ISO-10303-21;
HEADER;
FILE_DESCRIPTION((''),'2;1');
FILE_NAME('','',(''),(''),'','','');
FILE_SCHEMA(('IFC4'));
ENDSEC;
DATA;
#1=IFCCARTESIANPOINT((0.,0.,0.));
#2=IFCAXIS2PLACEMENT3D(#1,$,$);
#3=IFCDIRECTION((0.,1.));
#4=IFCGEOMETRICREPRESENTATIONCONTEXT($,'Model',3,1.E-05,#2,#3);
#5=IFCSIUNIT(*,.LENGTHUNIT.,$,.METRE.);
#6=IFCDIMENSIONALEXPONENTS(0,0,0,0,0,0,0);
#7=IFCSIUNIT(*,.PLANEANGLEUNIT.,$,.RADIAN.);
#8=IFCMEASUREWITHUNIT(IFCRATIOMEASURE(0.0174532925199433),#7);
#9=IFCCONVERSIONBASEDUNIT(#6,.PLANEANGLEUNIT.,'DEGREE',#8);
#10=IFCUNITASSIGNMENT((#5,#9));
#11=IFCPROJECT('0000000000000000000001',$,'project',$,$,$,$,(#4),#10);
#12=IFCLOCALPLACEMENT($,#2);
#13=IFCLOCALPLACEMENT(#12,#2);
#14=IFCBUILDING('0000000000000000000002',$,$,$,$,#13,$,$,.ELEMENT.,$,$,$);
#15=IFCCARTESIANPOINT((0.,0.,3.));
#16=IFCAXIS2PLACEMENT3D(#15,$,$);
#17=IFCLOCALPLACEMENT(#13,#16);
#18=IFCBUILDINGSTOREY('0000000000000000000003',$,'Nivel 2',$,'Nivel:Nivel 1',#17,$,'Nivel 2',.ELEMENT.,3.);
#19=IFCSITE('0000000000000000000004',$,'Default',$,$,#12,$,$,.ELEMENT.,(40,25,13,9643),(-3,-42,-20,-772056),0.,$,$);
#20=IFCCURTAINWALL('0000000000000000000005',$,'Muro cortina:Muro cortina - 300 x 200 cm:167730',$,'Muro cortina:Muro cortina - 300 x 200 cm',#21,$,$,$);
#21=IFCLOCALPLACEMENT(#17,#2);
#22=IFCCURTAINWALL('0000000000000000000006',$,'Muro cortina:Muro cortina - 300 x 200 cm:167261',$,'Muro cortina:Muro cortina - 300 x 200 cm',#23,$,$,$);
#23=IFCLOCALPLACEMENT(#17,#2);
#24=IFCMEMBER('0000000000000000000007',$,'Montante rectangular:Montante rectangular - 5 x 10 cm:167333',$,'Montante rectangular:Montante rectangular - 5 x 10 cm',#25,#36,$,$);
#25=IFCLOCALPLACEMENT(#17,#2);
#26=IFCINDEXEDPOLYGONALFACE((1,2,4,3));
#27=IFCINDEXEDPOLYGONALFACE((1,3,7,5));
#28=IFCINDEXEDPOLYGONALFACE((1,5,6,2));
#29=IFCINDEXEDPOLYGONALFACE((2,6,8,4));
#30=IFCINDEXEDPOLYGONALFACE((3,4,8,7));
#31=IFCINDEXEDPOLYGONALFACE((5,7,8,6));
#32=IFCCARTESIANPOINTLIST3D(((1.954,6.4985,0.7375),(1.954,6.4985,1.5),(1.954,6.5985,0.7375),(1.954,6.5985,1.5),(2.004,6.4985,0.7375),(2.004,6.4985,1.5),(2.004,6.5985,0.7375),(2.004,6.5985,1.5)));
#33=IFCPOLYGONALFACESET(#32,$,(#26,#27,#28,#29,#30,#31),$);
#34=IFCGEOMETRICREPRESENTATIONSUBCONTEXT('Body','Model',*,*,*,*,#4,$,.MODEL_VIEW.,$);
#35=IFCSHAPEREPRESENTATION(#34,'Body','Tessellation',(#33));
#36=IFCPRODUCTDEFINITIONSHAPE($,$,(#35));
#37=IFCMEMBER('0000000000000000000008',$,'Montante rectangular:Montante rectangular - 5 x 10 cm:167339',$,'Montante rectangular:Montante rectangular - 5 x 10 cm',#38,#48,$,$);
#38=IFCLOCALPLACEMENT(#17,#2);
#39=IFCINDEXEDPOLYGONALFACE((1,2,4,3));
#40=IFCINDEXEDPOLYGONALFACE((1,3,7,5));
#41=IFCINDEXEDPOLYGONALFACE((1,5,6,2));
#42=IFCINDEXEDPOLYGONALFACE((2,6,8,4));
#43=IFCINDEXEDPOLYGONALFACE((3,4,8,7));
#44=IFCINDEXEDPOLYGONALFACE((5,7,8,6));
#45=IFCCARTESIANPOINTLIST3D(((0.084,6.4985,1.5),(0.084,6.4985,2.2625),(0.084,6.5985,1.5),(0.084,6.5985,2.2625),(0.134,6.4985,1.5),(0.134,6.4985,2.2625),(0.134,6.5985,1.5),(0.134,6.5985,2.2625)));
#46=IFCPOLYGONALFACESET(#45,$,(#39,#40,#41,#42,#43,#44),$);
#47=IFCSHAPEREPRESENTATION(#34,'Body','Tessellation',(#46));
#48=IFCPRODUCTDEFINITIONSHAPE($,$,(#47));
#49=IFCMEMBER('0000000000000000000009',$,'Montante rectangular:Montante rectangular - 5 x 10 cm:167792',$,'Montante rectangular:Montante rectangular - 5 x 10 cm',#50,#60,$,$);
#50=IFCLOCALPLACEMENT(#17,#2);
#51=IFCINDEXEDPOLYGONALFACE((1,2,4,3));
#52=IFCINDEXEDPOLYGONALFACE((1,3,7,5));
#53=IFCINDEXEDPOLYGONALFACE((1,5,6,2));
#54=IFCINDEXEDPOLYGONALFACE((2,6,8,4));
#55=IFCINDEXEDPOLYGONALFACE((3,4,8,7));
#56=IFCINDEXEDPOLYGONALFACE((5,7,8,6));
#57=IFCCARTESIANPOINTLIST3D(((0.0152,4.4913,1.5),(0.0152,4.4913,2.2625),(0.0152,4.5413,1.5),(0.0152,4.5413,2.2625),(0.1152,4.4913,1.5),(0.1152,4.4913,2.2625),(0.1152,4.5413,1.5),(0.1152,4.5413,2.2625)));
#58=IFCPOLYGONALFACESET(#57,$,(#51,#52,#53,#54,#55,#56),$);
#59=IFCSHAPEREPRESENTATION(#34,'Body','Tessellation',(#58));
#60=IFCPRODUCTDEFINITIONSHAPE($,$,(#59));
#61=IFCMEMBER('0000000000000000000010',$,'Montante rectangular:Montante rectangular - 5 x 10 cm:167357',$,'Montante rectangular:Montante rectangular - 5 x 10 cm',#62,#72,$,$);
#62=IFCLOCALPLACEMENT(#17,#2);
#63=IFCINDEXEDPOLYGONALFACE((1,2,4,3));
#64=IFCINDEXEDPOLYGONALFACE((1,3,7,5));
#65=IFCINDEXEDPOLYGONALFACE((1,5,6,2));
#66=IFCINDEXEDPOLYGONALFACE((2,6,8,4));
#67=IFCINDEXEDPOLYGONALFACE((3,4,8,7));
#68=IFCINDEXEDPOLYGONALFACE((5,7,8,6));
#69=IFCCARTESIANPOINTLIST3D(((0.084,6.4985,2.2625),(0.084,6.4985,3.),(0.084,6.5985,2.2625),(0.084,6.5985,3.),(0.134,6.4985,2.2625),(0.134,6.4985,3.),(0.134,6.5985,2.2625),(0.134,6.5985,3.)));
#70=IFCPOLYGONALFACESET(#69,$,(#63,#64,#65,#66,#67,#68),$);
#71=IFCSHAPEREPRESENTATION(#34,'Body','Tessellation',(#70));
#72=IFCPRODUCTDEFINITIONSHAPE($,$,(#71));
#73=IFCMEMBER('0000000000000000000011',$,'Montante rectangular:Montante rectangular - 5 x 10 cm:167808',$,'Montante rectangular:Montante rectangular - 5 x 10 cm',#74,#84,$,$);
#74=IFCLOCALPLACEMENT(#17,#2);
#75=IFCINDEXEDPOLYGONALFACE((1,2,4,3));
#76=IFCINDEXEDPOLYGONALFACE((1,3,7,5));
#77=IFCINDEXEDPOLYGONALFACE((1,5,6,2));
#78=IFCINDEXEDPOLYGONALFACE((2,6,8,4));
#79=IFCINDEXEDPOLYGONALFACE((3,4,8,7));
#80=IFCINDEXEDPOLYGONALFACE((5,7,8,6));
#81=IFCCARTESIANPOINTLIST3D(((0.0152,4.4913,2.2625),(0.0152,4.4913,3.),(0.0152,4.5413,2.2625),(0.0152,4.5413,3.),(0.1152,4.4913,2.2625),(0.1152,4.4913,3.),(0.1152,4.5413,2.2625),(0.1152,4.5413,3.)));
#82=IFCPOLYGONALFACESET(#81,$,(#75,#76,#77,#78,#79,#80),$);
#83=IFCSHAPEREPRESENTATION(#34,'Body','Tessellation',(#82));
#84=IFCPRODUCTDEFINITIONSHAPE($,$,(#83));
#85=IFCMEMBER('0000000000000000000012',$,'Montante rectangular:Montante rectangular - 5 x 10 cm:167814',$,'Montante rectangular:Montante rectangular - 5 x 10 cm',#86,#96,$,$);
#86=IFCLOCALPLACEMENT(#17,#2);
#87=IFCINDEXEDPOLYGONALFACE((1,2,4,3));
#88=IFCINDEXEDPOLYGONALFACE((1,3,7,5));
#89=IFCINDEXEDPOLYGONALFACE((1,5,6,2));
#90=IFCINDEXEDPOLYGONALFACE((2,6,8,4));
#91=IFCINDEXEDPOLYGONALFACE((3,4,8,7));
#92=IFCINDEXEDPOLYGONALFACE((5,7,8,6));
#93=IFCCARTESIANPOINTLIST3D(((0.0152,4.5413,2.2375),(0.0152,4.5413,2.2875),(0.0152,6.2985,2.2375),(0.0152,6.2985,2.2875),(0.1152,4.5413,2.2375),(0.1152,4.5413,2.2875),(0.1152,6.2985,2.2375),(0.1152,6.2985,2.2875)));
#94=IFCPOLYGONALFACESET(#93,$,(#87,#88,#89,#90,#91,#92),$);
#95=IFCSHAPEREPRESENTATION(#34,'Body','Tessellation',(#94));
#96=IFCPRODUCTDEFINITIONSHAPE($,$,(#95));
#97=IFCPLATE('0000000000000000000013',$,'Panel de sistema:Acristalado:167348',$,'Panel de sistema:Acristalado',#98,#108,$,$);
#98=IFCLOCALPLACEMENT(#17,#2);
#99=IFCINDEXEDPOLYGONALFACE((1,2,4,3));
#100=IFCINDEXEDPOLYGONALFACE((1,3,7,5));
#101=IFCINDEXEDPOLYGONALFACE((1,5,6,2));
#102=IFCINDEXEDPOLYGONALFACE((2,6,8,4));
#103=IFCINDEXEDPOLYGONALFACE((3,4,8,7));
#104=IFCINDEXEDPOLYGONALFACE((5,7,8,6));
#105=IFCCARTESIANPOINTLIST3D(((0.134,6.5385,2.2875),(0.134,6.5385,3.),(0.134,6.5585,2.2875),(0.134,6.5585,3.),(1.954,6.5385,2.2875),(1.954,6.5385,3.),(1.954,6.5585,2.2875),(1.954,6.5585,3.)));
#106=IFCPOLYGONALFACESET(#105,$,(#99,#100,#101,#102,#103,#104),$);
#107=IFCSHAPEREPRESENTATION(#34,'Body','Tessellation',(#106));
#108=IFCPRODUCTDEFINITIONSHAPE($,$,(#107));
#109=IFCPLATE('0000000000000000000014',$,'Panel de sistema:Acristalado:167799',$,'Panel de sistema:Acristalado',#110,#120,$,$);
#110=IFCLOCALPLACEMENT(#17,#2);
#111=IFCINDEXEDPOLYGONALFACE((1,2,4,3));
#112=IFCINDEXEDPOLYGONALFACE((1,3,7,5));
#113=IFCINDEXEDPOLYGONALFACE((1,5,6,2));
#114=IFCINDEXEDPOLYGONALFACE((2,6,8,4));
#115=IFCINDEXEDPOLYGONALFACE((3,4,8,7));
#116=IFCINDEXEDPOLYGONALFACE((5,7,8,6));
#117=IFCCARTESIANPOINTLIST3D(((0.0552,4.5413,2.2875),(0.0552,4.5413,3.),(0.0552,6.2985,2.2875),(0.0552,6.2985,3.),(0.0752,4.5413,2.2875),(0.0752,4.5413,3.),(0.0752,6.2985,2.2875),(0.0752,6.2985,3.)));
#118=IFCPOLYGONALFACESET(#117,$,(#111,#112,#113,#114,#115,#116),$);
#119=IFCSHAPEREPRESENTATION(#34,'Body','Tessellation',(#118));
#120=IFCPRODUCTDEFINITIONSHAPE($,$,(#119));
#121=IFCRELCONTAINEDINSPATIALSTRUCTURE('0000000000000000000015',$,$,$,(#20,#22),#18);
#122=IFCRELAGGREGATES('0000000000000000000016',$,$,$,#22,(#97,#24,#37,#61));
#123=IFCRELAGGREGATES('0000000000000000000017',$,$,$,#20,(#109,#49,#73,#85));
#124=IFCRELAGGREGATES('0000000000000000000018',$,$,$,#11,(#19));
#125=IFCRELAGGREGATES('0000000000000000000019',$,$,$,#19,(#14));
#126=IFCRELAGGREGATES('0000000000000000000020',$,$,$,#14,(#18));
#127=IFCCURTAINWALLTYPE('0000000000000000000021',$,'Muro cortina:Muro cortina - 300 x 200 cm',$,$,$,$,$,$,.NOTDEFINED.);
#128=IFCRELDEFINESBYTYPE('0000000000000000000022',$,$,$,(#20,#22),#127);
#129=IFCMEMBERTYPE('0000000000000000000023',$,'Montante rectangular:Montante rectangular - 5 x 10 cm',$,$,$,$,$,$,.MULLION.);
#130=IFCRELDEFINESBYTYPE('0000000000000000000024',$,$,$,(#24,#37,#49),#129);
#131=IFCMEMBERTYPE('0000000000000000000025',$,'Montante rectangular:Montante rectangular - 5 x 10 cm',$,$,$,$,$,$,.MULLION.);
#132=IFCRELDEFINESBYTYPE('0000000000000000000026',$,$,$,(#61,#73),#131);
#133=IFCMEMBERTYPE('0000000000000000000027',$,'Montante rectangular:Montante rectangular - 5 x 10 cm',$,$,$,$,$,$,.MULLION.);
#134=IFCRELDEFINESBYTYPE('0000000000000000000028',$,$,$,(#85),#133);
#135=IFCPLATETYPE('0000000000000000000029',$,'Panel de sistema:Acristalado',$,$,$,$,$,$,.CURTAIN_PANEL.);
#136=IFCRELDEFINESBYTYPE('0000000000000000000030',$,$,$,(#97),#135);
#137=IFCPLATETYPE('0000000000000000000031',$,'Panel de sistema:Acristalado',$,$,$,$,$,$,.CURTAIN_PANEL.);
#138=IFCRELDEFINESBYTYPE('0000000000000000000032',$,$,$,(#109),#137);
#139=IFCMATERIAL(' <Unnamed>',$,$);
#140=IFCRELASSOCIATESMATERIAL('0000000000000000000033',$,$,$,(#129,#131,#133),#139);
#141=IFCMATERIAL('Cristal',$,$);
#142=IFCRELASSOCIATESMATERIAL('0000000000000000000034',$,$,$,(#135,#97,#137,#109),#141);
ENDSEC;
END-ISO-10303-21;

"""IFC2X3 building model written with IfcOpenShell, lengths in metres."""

from ifc_helpers import new_model, entity, si_unit, converted_unit, direction, frame, origin, origin_2d_with_axis, place, context, subcontext, project, spatial, rectangle, extrude, source, transform, mapped, material, type_object, type_shapes, element, aggregate, save


model = new_model("IFC2X3")

# Units and contexts
model_context = context("Model", 3, precision=1e-05, world=origin(), true_north=direction((0.0, 1.0)))
body_context = subcontext(model_context, "Body", "Model", "MODEL_VIEW")
ifc_project = project(units=[si_unit("LENGTHUNIT", "METRE"), converted_unit("PLANEANGLEUNIT", "DEGREE", entity("IfcRatioMeasure", 0.0174532925199433), si_unit("PLANEANGLEUNIT", "RADIAN"), dimensions=[0, 0, 0, 0, 0, 0, 0])], contexts=[model_context])

# Site, building, storey
site_placement = place(None, origin())
site = spatial("IfcSite", under=ifc_project, at=site_placement, Name="Default", CompositionType="ELEMENT", RefLatitude=(40, 25, 13, 9643), RefLongitude=(-3, -42, -20, -772056), RefElevation=0.0)
building_placement = place(site_placement, origin())
building = spatial("IfcBuilding", under=site, at=building_placement, CompositionType="ELEMENT")
storey_placement = place(building_placement, frame((0.0, 0.0, 3.0)))
storey = spatial("IfcBuildingStorey", under=building, at=storey_placement, Name="Nivel 2", ObjectType="Nivel:Nivel 1", LongName="Nivel 2", CompositionType="ELEMENT", Elevation=3.0)

# Curtain walls, members
curtain_wall_type = type_object("IfcCurtainWallType", Name="Muro cortina:Muro cortina - 300 x 200 cm", PredefinedType="NOTDEFINED")
curtain_wall_1_placement = place(storey_placement, frame((0.0, 0.0, -3.0)))
curtain_wall_1 = element("IfcCurtainWall", 1, at=curtain_wall_1_placement, inside=storey, type_object=curtain_wall_type, Name="Muro cortina:Muro cortina - 300 x 200 cm:167730", ObjectType="Muro cortina:Muro cortina - 300 x 200 cm")
ifc_material_1 = material(Name=" <Unnamed>")
curtain_wall_2_placement = place(storey_placement, frame((0.0, 0.0, -3.0)))
curtain_wall_2 = element("IfcCurtainWall", 2, at=curtain_wall_2_placement, inside=storey, type_object=curtain_wall_type, Name="Muro cortina:Muro cortina - 300 x 200 cm:167261", ObjectType="Muro cortina:Muro cortina - 300 x 200 cm")
member_type_1 = type_object("IfcMemberType", Name="Montante rectangular:Montante rectangular - 5 x 10 cm", PredefinedType="MULLION", material=ifc_material_1)
shared_shape_1 = source(origin(), body_context, "Body", "SweptSolid", [
    extrude(rectangle(XDim=0.1, YDim=0.05, at=origin_2d_with_axis()), frame((0.0, 0.0, -0.7625), z_axis=(0.0, 0.0, 1.0), x_axis=(0.0, -1.0, 0.0)), (0.0, 0.0, 1.0), 0.7625),
])
type_shapes(member_type_1, [shared_shape_1])
member_1_placement = place(storey_placement, frame((1.979, 6.5485, 0.7375), z_axis=(0.0, 0.0, -1.0), x_axis=(1.0, 0.0, 0.0)))
member_1 = element("IfcMember", 3, at=member_1_placement, type_object=member_type_1, Name="Montante rectangular:Montante rectangular - 5 x 10 cm:167333", ObjectType="Montante rectangular:Montante rectangular - 5 x 10 cm", context=body_context, shape_type="MappedRepresentation", body=[
    mapped(shared_shape_1, transform((0.0, 0.0, 0.0), scale=1.0)),
])
member_2_placement = place(storey_placement, frame((0.109, 6.5485, 1.5), z_axis=(0.0, 0.0, -1.0), x_axis=(1.0, 0.0, 0.0)))
member_2 = element("IfcMember", 4, at=member_2_placement, type_object=member_type_1, Name="Montante rectangular:Montante rectangular - 5 x 10 cm:167339", ObjectType="Montante rectangular:Montante rectangular - 5 x 10 cm", context=body_context, shape_type="MappedRepresentation", body=[
    mapped(shared_shape_1, transform((0.0, 0.0, 0.0), scale=1.0)),
])

# Members
member_3_placement = place(storey_placement, frame((0.0652, 4.5163, 1.5), z_axis=(0.0, 0.0, -1.0), x_axis=(0.0, -1.0, 0.0)))
member_3 = element("IfcMember", 5, at=member_3_placement, type_object=member_type_1, Name="Montante rectangular:Montante rectangular - 5 x 10 cm:167792", ObjectType="Montante rectangular:Montante rectangular - 5 x 10 cm", context=body_context, shape_type="MappedRepresentation", body=[
    mapped(shared_shape_1, transform((0.0, 0.0, 0.0), scale=1.0)),
])
member_type_2 = type_object("IfcMemberType", Name="Montante rectangular:Montante rectangular - 5 x 10 cm", PredefinedType="MULLION", material=ifc_material_1)
shared_shape_2 = source(origin(), body_context, "Body", "SweptSolid", [
    extrude(rectangle(XDim=0.1, YDim=0.05, at=origin_2d_with_axis()), frame((0.0, 0.0, -0.7375), z_axis=(0.0, 0.0, 1.0), x_axis=(0.0, -1.0, 0.0)), (0.0, 0.0, 1.0), 0.7375),
])
type_shapes(member_type_2, [shared_shape_2])
member_4_placement = place(storey_placement, frame((0.109, 6.5485, 2.2625), z_axis=(0.0, 0.0, -1.0), x_axis=(1.0, 0.0, 0.0)))
member_4 = element("IfcMember", 6, at=member_4_placement, type_object=member_type_2, Name="Montante rectangular:Montante rectangular - 5 x 10 cm:167357", ObjectType="Montante rectangular:Montante rectangular - 5 x 10 cm", context=body_context, shape_type="MappedRepresentation", body=[
    mapped(shared_shape_2, transform((0.0, 0.0, 0.0), scale=1.0)),
])
member_5_placement = place(storey_placement, frame((0.0652, 4.5163, 2.2625), z_axis=(0.0, 0.0, -1.0), x_axis=(0.0, -1.0, 0.0)))
member_5 = element("IfcMember", 7, at=member_5_placement, type_object=member_type_2, Name="Montante rectangular:Montante rectangular - 5 x 10 cm:167808", ObjectType="Montante rectangular:Montante rectangular - 5 x 10 cm", context=body_context, shape_type="MappedRepresentation", body=[
    mapped(shared_shape_2, transform((0.0, 0.0, 0.0), scale=1.0)),
])
member_type_3 = type_object("IfcMemberType", Name="Montante rectangular:Montante rectangular - 5 x 10 cm", PredefinedType="MULLION", material=ifc_material_1)
shared_shape_3 = source(origin(), body_context, "Body", "SweptSolid", [
    extrude(rectangle(XDim=0.1, YDim=0.05, at=origin_2d_with_axis()), frame((0.0, 0.0, -1.7571), z_axis=(0.0, 0.0, 1.0), x_axis=(0.0, -1.0, 0.0)), (0.0, 0.0, 1.0), 1.7571),
])
type_shapes(member_type_3, [shared_shape_3])
member_6_placement = place(storey_placement, frame((0.0652, 4.5413, 2.2625), z_axis=(0.0, -1.0, 0.0), x_axis=(0.0, 0.0, 1.0)))
member_6 = element("IfcMember", 8, at=member_6_placement, type_object=member_type_3, Name="Montante rectangular:Montante rectangular - 5 x 10 cm:167814", ObjectType="Montante rectangular:Montante rectangular - 5 x 10 cm", context=body_context, shape_type="MappedRepresentation", body=[
    mapped(shared_shape_3, transform((0.0, 0.0, 0.0), scale=1.0)),
])

# Plates
ifc_material_2 = material(Name="Cristal")
plate_type_1 = type_object("IfcPlateType", Name="Panel de sistema:Acristalado", PredefinedType="CURTAIN_PANEL", material=ifc_material_2)
shared_shape_4 = source(origin(), body_context, "Body", "SweptSolid", [
    extrude(rectangle(XDim=0.02, YDim=1.82, at=origin_2d_with_axis()), frame((0.0, 0.0, 0.0), z_axis=(0.0, 0.0, 1.0), x_axis=(0.0, 1.0, 0.0)), (0.0, 0.0, 1.0), 0.7125),
])
type_shapes(plate_type_1, [shared_shape_4])
plate_1_placement = place(curtain_wall_2_placement, frame((1.044, 6.5485, 5.2875)))
plate_1 = element("IfcPlate", 9, at=plate_1_placement, type_object=plate_type_1, material=ifc_material_2, Name="Panel de sistema:Acristalado:167348", ObjectType="Panel de sistema:Acristalado", context=body_context, shape_type="MappedRepresentation", body=[
    mapped(shared_shape_4, transform((0.0, 0.0, 0.0), scale=1.0)),
])
aggregate(curtain_wall_2, [plate_1, member_1, member_2, member_4])
plate_type_2 = type_object("IfcPlateType", Name="Panel de sistema:Acristalado", PredefinedType="CURTAIN_PANEL", material=ifc_material_2)
shared_shape_5 = source(origin(), body_context, "Body", "SweptSolid", [
    extrude(rectangle(XDim=0.02, YDim=1.7571, at=origin_2d_with_axis()), frame((0.0, 0.0, 0.0), z_axis=(0.0, 0.0, 1.0), x_axis=(0.0, 1.0, 0.0)), (0.0, 0.0, 1.0), 0.7125),
])
type_shapes(plate_type_2, [shared_shape_5])
plate_2_placement = place(curtain_wall_1_placement, frame((0.0652, 5.4199, 5.2875), z_axis=(0.0, 0.0, 1.0), x_axis=(0.0, -1.0, 0.0)))
plate_2 = element("IfcPlate", 10, at=plate_2_placement, type_object=plate_type_2, material=ifc_material_2, Name="Panel de sistema:Acristalado:167799", ObjectType="Panel de sistema:Acristalado", context=body_context, shape_type="MappedRepresentation", body=[
    mapped(shared_shape_5, transform((0.0, 0.0, 0.0), scale=1.0)),
])
aggregate(curtain_wall_1, [plate_2, member_3, member_5, member_6])

save(model, "model.ifc")
